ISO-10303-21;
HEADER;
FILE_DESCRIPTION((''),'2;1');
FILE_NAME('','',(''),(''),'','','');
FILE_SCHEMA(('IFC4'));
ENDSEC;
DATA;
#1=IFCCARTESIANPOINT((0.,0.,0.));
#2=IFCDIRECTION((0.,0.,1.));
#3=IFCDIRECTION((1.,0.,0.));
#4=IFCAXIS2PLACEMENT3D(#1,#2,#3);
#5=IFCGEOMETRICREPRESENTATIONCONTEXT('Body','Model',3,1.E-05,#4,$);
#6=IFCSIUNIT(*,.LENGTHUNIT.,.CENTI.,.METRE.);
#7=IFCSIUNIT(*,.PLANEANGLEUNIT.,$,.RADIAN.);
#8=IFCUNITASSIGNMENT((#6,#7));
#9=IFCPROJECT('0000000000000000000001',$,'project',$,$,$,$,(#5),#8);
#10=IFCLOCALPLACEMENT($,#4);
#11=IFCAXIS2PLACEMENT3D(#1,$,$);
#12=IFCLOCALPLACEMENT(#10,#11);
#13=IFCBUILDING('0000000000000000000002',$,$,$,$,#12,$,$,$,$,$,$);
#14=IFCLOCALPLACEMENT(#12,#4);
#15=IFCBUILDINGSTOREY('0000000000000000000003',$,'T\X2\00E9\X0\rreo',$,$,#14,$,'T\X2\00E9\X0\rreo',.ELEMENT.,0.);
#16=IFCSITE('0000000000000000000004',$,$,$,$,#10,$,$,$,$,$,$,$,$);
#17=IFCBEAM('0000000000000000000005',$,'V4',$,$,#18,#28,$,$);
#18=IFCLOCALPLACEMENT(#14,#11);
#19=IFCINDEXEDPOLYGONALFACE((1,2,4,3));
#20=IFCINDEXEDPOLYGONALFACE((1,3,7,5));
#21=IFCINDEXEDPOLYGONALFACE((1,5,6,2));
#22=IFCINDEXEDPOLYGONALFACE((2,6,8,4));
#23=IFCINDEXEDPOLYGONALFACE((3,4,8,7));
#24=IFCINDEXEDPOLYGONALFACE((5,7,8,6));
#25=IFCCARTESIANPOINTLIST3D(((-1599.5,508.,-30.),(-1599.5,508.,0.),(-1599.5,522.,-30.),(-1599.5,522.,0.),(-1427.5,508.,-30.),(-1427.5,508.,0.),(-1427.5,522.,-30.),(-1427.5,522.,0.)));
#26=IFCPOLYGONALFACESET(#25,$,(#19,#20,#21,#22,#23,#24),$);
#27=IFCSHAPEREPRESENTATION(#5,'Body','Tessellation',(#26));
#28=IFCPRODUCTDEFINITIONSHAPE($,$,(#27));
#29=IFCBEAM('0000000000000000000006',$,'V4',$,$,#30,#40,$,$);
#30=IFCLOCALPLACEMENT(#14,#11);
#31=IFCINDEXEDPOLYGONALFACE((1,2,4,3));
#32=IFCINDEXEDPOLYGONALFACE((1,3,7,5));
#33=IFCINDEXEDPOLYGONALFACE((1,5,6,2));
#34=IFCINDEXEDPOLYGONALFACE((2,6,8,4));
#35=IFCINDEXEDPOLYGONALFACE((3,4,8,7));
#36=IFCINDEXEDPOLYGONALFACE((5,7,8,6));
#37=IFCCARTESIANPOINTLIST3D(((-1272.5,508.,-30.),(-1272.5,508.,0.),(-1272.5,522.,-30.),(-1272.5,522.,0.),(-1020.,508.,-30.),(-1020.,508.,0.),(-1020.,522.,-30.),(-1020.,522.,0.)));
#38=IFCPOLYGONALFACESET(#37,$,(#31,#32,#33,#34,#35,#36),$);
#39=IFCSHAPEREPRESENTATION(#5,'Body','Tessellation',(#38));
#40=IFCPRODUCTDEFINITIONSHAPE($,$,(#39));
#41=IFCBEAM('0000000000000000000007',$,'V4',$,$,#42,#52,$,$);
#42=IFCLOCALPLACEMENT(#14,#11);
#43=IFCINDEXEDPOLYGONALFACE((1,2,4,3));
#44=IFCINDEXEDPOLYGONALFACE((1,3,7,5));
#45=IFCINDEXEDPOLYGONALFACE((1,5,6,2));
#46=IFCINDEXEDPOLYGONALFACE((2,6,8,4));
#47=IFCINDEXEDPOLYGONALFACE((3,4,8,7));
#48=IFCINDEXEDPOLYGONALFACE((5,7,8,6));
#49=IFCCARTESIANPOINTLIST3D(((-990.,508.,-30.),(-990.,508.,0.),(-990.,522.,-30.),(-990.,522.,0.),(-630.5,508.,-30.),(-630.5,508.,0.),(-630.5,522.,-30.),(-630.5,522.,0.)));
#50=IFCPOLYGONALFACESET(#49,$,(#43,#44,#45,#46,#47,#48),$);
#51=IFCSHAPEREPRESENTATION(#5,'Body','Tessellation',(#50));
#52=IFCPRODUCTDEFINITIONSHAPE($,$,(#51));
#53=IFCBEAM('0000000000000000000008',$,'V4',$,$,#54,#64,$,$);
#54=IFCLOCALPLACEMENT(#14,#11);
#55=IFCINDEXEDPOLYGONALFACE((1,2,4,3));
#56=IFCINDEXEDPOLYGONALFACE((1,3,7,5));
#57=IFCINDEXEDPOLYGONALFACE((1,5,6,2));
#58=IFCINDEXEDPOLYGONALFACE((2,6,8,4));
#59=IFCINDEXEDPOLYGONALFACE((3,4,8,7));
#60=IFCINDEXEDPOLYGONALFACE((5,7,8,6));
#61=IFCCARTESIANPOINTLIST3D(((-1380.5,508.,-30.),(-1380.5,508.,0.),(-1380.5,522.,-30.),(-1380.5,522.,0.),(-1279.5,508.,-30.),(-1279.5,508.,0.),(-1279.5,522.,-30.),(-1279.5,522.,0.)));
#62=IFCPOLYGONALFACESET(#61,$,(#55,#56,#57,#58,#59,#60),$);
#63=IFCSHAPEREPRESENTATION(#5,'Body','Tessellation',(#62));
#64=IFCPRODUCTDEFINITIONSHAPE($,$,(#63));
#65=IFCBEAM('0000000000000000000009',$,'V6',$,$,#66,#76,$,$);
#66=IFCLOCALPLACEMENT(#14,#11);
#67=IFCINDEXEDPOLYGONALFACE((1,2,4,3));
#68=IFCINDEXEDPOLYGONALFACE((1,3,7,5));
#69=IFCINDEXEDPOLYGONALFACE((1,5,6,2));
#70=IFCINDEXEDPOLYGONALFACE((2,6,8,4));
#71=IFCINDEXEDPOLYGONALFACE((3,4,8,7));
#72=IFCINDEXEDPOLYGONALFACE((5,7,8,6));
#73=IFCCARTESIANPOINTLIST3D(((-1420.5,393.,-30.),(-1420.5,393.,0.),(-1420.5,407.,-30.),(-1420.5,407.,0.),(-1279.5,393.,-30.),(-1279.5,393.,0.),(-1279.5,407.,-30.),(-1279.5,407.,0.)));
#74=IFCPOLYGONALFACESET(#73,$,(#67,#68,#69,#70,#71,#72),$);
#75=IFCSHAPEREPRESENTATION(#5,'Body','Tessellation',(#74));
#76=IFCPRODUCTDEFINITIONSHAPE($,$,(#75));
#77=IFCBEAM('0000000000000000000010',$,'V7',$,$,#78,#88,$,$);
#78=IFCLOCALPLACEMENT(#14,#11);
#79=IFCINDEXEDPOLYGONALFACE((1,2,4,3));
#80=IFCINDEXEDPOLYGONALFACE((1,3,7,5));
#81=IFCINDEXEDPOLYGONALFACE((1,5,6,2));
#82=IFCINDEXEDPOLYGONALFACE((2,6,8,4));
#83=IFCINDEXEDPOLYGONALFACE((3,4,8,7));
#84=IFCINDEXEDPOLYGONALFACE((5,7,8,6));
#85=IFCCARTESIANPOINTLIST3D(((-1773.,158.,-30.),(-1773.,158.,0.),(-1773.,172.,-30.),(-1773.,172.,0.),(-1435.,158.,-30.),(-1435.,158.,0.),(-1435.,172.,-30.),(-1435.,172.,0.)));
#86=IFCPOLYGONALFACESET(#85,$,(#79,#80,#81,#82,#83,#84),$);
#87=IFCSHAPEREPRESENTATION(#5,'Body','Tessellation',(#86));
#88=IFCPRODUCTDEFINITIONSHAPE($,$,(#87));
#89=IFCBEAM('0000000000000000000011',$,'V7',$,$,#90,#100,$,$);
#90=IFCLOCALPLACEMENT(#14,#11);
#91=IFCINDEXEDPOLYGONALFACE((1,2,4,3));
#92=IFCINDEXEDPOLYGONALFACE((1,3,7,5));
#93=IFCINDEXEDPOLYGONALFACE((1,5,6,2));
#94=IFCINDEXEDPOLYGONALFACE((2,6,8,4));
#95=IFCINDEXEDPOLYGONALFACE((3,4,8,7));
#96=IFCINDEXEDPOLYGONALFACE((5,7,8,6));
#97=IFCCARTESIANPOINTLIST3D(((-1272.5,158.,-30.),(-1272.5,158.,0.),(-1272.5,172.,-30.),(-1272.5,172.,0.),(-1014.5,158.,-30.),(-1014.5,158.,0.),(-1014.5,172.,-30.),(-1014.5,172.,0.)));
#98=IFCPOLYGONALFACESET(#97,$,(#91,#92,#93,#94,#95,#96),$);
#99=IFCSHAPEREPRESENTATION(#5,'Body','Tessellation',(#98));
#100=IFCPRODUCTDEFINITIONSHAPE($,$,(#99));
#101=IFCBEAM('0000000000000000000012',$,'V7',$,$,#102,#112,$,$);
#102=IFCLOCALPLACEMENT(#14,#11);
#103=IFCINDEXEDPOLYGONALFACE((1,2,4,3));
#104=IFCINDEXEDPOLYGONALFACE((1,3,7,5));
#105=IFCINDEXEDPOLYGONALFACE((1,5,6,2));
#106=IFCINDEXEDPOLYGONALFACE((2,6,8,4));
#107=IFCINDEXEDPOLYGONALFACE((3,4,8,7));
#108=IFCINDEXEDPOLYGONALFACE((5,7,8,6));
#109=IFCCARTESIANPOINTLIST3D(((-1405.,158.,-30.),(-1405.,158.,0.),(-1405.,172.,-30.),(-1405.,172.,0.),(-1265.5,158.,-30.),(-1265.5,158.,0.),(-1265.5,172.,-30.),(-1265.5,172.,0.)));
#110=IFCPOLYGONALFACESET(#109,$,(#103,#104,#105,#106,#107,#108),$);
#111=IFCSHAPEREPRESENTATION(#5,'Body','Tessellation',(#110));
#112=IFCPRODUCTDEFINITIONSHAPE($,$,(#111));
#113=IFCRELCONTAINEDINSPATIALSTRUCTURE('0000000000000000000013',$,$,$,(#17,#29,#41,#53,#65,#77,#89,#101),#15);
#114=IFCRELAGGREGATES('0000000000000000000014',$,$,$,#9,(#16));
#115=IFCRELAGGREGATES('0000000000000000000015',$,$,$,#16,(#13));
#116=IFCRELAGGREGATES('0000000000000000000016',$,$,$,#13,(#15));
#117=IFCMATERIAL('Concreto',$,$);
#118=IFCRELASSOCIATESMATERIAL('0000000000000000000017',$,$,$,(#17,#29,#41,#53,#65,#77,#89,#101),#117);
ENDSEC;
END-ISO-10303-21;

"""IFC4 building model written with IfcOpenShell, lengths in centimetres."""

from ifc_helpers import new_model, si_unit, frame, origin, origin_with_axes, origin_2d_with_axis, place, context, project, spatial, rectangle, extrude, material, element, save


model = new_model("IFC4")

# Units and contexts
model_context = context("Model", 3, precision=1e-05, world=origin_with_axes(), identifier="Body")
ifc_project = project(units=[si_unit("LENGTHUNIT", "METRE", prefix="CENTI"), si_unit("PLANEANGLEUNIT", "RADIAN")], contexts=[model_context])

# Site, building, storey
site_placement = place(None, origin_with_axes())
site = spatial("IfcSite", under=ifc_project, at=site_placement)
building_placement = place(site_placement, origin())
building = spatial("IfcBuilding", under=site, at=building_placement)
storey_placement = place(building_placement, origin_with_axes())
storey = spatial("IfcBuildingStorey", under=building, at=storey_placement, Name="Térreo", LongName="Térreo", CompositionType="ELEMENT", Elevation=0.0)

# Shared definitions
ifc_material = material(Name="Concreto")

# Beams
beam_1_placement = place(storey_placement, frame((-1513.5, 515.0, 0.0), z_axis=(0.0, 0.0, 1.0), x_axis=(1.0, 0.0, 0.0)))
element("IfcBeam", 1, at=beam_1_placement, inside=storey, material=ifc_material, Name="V4", context=model_context, shape_type="SolidModel", body=[
    extrude(rectangle(XDim=14.0, YDim=30.0, at=origin_2d_with_axis()), frame((-86.0, 0.0, -15.0), z_axis=(1.0, 0.0, 0.0), x_axis=(0.0, -1.0, 0.0)), (0.0, 0.0, 1.0), 172.0),
])
beam_2_placement = place(storey_placement, frame((-1146.25, 515.0, 0.0), z_axis=(0.0, 0.0, 1.0), x_axis=(1.0, 0.0, 0.0)))
element("IfcBeam", 2, at=beam_2_placement, inside=storey, material=ifc_material, Name="V4", context=model_context, shape_type="SolidModel", body=[
    extrude(rectangle(XDim=14.0, YDim=30.0, at=origin_2d_with_axis()), frame((-126.25, 0.0, -15.0), z_axis=(1.0, 0.0, 0.0), x_axis=(0.0, -1.0, 0.0)), (0.0, 0.0, 1.0), 252.5),
])
beam_3_placement = place(storey_placement, frame((-810.25, 515.0, 0.0), z_axis=(0.0, 0.0, 1.0), x_axis=(1.0, 0.0, 0.0)))
element("IfcBeam", 3, at=beam_3_placement, inside=storey, material=ifc_material, Name="V4", context=model_context, shape_type="SolidModel", body=[
    extrude(rectangle(XDim=14.0, YDim=30.0, at=origin_2d_with_axis()), frame((-179.75, 0.0, -15.0), z_axis=(1.0, 0.0, 0.0), x_axis=(0.0, -1.0, 0.0)), (0.0, 0.0, 1.0), 359.5),
])
beam_4_placement = place(storey_placement, frame((-1330.0, 515.0, 0.0), z_axis=(0.0, 0.0, 1.0), x_axis=(1.0, 0.0, 0.0)))
element("IfcBeam", 4, at=beam_4_placement, inside=storey, material=ifc_material, Name="V4", context=model_context, shape_type="SolidModel", body=[
    extrude(rectangle(XDim=14.0, YDim=30.0, at=origin_2d_with_axis()), frame((-50.5, 0.0, -15.0), z_axis=(1.0, 0.0, 0.0), x_axis=(0.0, -1.0, 0.0)), (0.0, 0.0, 1.0), 101.0),
])
beam_5_placement = place(storey_placement, frame((-1350.0, 400.0, 0.0), z_axis=(0.0, 0.0, 1.0), x_axis=(1.0, 0.0, 0.0)))
element("IfcBeam", 5, at=beam_5_placement, inside=storey, material=ifc_material, Name="V6", context=model_context, shape_type="SolidModel", body=[
    extrude(rectangle(XDim=14.0, YDim=30.0, at=origin_2d_with_axis()), frame((-70.5, 0.0, -15.0), z_axis=(1.0, 0.0, 0.0), x_axis=(0.0, -1.0, 0.0)), (0.0, 0.0, 1.0), 141.0),
])
beam_6_placement = place(storey_placement, frame((-1604.0, 165.0, 0.0), z_axis=(0.0, 0.0, 1.0), x_axis=(1.0, 0.0, 0.0)))
element("IfcBeam", 6, at=beam_6_placement, inside=storey, material=ifc_material, Name="V7", context=model_context, shape_type="SolidModel", body=[
    extrude(rectangle(XDim=14.0, YDim=30.0, at=origin_2d_with_axis()), frame((-169.0, 0.0, -15.0), z_axis=(1.0, 0.0, 0.0), x_axis=(0.0, -1.0, 0.0)), (0.0, 0.0, 1.0), 338.0),
])
beam_7_placement = place(storey_placement, frame((-1143.5, 165.0, 0.0), z_axis=(0.0, 0.0, 1.0), x_axis=(1.0, 0.0, 0.0)))
element("IfcBeam", 7, at=beam_7_placement, inside=storey, material=ifc_material, Name="V7", context=model_context, shape_type="SolidModel", body=[
    extrude(rectangle(XDim=14.0, YDim=30.0, at=origin_2d_with_axis()), frame((-129.0, 0.0, -15.0), z_axis=(1.0, 0.0, 0.0), x_axis=(0.0, -1.0, 0.0)), (0.0, 0.0, 1.0), 258.0),
])
beam_8_placement = place(storey_placement, frame((-1335.25, 165.0, 0.0), z_axis=(0.0, 0.0, 1.0), x_axis=(1.0, 0.0, 0.0)))
element("IfcBeam", 8, at=beam_8_placement, inside=storey, material=ifc_material, Name="V7", context=model_context, shape_type="SolidModel", body=[
    extrude(rectangle(XDim=14.0, YDim=30.0, at=origin_2d_with_axis()), frame((-69.75, 0.0, -15.0), z_axis=(1.0, 0.0, 0.0), x_axis=(0.0, -1.0, 0.0)), (0.0, 0.0, 1.0), 139.5),
])

save(model, "model.ifc")
